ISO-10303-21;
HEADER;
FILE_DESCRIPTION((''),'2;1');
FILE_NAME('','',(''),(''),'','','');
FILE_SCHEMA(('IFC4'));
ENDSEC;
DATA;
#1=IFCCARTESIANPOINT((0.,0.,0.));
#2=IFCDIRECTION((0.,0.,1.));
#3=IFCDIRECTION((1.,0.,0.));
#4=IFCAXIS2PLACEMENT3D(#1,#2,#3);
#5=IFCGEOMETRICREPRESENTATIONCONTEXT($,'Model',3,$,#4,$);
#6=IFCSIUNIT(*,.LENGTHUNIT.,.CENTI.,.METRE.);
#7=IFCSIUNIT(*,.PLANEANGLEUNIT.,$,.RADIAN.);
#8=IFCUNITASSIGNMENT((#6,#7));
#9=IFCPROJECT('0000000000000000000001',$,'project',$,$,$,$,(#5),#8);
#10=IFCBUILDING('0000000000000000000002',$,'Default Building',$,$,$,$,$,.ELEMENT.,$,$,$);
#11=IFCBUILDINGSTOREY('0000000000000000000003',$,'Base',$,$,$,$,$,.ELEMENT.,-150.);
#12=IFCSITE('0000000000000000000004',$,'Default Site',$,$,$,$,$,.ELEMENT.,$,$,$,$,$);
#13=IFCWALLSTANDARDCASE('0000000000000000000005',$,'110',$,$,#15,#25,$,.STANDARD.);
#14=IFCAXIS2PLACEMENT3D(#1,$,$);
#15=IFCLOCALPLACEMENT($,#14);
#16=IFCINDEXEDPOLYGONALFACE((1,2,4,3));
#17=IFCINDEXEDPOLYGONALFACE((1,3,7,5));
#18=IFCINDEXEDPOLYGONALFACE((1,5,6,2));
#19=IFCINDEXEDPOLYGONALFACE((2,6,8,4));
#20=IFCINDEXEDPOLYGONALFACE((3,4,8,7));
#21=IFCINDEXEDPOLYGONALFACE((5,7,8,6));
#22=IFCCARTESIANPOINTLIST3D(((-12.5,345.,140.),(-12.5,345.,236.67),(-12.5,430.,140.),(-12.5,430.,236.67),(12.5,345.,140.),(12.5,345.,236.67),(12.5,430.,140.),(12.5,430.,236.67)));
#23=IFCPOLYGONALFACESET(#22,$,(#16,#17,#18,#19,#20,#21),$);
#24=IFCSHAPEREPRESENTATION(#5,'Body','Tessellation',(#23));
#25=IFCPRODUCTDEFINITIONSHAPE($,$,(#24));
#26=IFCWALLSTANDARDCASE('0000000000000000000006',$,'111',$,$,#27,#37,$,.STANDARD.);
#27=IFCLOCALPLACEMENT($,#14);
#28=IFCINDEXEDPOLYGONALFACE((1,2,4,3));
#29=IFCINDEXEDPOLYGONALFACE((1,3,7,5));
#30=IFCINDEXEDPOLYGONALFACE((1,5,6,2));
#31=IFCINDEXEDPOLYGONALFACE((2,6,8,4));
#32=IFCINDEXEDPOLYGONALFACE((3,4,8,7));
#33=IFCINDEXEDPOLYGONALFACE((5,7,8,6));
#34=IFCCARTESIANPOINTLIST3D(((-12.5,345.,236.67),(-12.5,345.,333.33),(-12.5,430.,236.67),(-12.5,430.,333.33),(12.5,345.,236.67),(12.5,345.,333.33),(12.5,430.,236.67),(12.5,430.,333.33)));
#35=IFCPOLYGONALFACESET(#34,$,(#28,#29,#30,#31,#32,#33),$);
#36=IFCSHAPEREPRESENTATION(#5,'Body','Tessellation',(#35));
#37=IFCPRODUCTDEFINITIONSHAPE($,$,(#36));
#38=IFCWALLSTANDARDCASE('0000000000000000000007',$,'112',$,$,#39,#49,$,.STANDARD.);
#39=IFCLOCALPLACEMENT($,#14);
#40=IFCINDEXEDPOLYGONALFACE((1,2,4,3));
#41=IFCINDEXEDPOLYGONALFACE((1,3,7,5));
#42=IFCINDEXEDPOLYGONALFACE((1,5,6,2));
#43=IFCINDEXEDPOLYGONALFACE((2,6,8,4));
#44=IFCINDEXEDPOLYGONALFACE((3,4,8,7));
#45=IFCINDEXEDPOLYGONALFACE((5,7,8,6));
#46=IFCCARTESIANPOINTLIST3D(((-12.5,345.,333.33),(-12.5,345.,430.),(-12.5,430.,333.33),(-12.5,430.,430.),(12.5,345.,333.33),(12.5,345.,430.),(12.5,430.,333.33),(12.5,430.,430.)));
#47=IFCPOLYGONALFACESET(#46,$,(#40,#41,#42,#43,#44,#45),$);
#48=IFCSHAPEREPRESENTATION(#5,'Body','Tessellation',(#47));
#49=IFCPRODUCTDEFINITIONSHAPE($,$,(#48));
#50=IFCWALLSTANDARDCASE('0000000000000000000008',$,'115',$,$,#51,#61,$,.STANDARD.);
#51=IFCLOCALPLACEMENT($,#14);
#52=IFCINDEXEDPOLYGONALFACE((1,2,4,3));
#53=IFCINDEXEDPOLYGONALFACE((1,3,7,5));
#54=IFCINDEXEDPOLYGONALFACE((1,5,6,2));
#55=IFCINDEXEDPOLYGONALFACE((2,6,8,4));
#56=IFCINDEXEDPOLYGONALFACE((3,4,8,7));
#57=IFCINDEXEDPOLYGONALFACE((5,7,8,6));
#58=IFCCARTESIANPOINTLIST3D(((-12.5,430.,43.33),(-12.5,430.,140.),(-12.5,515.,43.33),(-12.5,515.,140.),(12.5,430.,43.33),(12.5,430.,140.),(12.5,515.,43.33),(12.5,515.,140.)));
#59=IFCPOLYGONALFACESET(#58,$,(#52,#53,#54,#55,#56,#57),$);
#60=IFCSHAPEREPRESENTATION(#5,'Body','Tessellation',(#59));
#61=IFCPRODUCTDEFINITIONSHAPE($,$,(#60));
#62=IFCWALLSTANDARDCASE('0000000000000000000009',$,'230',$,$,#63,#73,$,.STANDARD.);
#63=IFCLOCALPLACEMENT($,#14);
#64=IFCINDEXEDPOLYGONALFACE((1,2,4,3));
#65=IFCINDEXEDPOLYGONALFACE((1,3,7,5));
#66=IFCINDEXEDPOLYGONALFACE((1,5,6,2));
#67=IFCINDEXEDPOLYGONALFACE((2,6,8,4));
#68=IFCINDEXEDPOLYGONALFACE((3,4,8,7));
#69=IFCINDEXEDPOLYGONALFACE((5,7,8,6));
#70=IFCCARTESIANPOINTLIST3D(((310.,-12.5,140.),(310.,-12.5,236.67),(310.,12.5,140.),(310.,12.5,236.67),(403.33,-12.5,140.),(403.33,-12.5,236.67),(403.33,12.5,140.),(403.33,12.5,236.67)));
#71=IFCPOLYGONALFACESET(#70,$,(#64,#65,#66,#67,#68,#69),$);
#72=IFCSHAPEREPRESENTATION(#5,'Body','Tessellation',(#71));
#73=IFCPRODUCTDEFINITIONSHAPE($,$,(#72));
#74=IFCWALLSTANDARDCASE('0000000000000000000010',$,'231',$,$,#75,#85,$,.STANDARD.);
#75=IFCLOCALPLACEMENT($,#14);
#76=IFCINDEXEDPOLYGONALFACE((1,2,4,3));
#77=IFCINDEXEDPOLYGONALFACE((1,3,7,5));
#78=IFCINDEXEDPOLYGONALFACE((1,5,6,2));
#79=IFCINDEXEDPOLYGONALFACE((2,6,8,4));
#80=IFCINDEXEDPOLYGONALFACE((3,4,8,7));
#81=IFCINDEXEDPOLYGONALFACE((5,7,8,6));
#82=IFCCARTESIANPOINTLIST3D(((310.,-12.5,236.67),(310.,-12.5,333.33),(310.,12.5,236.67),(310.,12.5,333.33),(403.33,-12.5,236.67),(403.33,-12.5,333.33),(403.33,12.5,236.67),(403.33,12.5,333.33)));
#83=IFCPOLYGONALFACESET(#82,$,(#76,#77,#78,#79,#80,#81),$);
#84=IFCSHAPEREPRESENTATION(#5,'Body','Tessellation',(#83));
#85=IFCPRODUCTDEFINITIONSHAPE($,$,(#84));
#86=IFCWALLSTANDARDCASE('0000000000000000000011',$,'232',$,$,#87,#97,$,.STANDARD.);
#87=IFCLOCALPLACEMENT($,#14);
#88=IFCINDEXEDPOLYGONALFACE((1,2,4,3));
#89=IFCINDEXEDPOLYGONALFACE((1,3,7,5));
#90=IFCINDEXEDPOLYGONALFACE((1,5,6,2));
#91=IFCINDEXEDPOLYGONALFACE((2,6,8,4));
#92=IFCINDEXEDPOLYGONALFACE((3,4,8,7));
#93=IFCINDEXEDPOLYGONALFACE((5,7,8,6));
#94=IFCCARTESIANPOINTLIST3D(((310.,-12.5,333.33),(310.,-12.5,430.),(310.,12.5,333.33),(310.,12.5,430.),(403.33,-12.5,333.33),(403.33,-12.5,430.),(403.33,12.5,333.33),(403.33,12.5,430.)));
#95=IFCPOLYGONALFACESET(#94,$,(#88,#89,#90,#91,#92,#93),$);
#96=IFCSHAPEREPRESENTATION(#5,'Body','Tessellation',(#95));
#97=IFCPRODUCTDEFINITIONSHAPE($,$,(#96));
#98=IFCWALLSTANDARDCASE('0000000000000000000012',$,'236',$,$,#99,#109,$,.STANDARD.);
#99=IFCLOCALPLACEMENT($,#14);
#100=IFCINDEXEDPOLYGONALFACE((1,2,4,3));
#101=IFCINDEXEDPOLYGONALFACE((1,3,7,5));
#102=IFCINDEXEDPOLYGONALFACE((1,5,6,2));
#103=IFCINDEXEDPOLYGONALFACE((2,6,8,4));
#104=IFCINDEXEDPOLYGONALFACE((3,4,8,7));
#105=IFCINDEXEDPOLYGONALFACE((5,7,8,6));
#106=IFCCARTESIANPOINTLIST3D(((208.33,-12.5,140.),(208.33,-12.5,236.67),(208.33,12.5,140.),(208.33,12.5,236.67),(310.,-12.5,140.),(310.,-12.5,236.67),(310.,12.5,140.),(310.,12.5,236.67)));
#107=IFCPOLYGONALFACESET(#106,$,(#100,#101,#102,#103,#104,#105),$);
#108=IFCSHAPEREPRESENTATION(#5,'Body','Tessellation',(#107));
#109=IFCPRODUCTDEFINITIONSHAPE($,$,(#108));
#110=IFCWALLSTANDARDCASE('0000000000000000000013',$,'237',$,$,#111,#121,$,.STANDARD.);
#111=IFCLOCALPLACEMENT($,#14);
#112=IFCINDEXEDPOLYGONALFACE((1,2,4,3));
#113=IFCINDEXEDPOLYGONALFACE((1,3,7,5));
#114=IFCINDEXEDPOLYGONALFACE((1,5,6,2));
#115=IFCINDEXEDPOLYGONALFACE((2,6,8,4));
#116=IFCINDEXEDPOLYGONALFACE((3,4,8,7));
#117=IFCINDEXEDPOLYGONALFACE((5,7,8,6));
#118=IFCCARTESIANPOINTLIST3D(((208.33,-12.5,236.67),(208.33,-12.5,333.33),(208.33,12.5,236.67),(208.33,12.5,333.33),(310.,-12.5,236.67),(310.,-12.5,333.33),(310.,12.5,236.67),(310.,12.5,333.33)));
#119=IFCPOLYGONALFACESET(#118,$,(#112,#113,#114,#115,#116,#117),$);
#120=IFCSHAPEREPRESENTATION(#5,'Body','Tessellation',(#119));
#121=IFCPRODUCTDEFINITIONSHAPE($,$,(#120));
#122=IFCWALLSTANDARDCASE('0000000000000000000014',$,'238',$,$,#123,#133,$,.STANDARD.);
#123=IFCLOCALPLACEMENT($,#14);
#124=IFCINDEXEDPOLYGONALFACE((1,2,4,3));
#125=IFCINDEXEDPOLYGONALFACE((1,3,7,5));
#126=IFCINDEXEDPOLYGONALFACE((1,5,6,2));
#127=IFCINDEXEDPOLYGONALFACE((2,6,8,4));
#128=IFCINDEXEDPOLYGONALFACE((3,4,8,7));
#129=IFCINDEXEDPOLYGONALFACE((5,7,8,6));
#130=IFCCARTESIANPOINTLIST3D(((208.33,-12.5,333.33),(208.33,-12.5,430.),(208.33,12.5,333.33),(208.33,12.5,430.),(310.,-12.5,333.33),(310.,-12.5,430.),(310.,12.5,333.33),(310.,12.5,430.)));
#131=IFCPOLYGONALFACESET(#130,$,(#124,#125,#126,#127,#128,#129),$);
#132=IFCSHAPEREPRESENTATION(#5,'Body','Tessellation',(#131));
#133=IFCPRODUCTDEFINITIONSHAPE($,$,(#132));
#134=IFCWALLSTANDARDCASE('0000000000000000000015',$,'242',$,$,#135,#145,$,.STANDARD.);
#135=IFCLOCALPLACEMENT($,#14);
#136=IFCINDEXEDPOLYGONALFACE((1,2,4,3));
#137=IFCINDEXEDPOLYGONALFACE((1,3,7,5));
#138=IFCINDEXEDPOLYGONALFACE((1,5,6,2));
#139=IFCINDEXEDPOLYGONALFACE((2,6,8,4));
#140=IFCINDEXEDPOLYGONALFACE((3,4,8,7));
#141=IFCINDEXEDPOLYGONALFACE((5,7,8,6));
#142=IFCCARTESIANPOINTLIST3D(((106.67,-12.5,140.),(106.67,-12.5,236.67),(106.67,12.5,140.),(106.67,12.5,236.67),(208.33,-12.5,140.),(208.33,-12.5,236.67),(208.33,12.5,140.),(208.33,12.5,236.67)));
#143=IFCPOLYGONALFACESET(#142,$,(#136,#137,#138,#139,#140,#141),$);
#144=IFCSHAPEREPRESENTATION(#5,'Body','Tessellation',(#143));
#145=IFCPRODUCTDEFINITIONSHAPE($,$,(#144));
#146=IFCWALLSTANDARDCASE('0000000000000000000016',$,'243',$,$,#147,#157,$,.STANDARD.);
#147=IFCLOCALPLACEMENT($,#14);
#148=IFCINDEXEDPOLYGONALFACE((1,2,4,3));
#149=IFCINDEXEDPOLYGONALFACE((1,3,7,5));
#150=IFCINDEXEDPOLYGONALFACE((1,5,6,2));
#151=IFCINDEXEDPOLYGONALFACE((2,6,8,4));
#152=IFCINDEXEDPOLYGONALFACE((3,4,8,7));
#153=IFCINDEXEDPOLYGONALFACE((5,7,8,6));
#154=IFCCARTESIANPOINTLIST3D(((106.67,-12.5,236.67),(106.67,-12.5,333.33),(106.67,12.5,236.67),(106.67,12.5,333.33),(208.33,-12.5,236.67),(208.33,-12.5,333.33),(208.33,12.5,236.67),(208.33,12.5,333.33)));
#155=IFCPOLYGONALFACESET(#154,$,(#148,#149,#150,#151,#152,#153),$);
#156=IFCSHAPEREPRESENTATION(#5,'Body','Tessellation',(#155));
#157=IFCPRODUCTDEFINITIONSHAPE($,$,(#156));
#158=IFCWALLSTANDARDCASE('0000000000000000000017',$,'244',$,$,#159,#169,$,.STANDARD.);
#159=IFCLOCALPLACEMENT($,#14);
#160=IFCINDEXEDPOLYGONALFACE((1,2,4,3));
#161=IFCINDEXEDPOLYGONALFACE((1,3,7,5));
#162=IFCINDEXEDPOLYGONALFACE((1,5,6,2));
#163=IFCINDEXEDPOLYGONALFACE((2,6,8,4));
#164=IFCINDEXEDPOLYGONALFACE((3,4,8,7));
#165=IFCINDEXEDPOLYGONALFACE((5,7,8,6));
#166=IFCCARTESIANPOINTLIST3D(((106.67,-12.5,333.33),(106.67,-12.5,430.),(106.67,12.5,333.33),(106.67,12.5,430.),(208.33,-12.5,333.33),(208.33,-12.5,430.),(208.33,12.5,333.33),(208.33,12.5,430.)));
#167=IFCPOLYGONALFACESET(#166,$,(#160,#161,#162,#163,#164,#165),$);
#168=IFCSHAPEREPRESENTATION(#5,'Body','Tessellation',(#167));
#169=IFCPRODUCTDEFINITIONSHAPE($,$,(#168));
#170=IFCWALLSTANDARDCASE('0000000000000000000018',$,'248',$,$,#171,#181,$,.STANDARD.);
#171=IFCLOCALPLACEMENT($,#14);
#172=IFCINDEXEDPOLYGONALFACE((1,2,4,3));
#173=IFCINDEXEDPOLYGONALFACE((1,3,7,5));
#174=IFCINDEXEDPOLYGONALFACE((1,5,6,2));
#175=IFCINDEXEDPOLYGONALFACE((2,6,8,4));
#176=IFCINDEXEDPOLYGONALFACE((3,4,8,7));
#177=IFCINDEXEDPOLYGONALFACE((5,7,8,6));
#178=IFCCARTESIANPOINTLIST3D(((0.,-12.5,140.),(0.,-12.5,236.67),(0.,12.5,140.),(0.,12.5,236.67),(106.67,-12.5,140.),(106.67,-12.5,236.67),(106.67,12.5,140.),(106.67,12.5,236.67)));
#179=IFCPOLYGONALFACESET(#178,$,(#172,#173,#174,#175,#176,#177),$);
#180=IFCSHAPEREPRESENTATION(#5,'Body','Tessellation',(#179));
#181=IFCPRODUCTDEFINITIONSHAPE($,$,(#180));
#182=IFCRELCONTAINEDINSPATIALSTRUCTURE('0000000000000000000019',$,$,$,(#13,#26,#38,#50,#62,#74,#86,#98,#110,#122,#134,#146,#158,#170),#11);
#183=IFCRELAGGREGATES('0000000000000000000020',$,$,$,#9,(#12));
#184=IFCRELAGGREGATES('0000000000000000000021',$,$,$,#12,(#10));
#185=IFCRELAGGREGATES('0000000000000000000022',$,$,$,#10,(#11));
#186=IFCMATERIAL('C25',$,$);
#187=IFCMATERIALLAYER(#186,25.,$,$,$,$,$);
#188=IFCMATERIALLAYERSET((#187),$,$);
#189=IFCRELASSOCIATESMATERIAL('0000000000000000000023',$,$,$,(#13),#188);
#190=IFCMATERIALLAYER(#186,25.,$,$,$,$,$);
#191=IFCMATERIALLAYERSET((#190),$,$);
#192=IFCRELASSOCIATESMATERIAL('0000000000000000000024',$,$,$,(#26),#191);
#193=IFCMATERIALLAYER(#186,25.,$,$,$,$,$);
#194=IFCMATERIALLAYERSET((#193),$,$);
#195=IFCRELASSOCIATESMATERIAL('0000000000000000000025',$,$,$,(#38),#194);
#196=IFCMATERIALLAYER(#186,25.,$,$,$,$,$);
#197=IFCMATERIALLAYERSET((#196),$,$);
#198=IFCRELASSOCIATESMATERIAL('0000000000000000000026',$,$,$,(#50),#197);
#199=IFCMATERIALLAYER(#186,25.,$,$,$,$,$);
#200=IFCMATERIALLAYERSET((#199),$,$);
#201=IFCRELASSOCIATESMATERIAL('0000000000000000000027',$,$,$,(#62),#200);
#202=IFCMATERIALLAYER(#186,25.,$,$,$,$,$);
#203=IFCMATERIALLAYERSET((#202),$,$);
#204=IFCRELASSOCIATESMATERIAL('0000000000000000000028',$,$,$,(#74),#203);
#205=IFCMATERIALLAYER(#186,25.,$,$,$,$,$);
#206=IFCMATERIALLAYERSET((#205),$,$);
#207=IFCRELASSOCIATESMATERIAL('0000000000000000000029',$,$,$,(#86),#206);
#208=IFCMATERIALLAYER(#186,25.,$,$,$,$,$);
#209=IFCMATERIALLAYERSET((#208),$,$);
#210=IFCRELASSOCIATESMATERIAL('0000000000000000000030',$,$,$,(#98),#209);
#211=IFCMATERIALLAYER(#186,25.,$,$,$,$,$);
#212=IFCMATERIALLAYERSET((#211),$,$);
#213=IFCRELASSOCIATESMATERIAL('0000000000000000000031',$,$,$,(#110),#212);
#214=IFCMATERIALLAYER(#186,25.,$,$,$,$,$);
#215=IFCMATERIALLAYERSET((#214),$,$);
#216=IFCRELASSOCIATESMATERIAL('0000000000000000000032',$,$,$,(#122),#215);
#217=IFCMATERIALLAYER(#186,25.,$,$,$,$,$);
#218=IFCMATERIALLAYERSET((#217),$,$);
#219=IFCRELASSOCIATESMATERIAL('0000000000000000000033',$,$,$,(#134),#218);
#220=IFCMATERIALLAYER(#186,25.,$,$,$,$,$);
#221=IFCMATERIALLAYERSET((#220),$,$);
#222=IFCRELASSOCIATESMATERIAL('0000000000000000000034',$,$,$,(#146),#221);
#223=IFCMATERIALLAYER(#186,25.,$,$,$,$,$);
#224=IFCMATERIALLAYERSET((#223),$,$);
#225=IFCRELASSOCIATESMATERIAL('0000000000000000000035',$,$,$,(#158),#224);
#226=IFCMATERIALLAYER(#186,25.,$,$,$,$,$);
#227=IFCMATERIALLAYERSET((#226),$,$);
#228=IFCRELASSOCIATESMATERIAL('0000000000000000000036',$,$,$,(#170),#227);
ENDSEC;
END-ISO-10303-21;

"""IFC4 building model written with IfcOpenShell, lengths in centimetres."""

from ifc_helpers import new_model, si_unit, frame, origin_with_axes, origin_2d_with_axis, place, context, project, spatial, rectangle, extrude, material, layer, layer_set, layer_usage, element, save


model = new_model("IFC4")

# Units and contexts
model_context = context("Model", 3, world=origin_with_axes())
ifc_project = project(units=[si_unit("LENGTHUNIT", "METRE", prefix="CENTI"), si_unit("PLANEANGLEUNIT", "RADIAN")], contexts=[model_context])

# Site, building, storey
site = spatial("IfcSite", under=ifc_project, Name="Default Site", CompositionType="ELEMENT")
building = spatial("IfcBuilding", under=site, Name="Default Building", CompositionType="ELEMENT")
storey = spatial("IfcBuildingStorey", under=building, Name="Base", CompositionType="ELEMENT", Elevation=-150.0)

# Walls
ifc_material = material(Name="C25")
ifc_layer_1 = layer(ifc_material, 25.0)
ifc_layer_set_1 = layer_set([ifc_layer_1])
ifc_layer_usage_1 = layer_usage(ifc_layer_set_1, "AXIS2", "POSITIVE", -25.0)
wall_1_placement = place(None, frame((0.0, 387.5, 140.0), z_axis=(0.0, 0.0, 1.0), x_axis=(0.0, 1.0, 0.0)))
element("IfcWallStandardCase", 1, at=wall_1_placement, inside=storey, material=ifc_layer_usage_1, Name="110", PredefinedType="STANDARD", context=model_context, shape_type="SweptSolid", body=[
    extrude(rectangle(XDim=85.0, YDim=25.0, at=origin_2d_with_axis()), origin_with_axes(), (0.0, 0.0, 1.0), 96.67),
])
ifc_layer_2 = layer(ifc_material, 25.0)
ifc_layer_set_2 = layer_set([ifc_layer_2])
ifc_layer_usage_2 = layer_usage(ifc_layer_set_2, "AXIS2", "POSITIVE", -25.0)
wall_2_placement = place(None, frame((0.0, 387.5, 236.67), z_axis=(0.0, 0.0, 1.0), x_axis=(0.0, 1.0, 0.0)))
element("IfcWallStandardCase", 2, at=wall_2_placement, inside=storey, material=ifc_layer_usage_2, Name="111", PredefinedType="STANDARD", context=model_context, shape_type="SweptSolid", body=[
    extrude(rectangle(XDim=85.0, YDim=25.0, at=origin_2d_with_axis()), origin_with_axes(), (0.0, 0.0, 1.0), 96.67),
])
ifc_layer_3 = layer(ifc_material, 25.0)
ifc_layer_set_3 = layer_set([ifc_layer_3])
ifc_layer_usage_3 = layer_usage(ifc_layer_set_3, "AXIS2", "POSITIVE", -25.0)
wall_3_placement = place(None, frame((0.0, 387.5, 333.33), z_axis=(0.0, 0.0, 1.0), x_axis=(0.0, 1.0, 0.0)))
element("IfcWallStandardCase", 3, at=wall_3_placement, inside=storey, material=ifc_layer_usage_3, Name="112", PredefinedType="STANDARD", context=model_context, shape_type="SweptSolid", body=[
    extrude(rectangle(XDim=85.0, YDim=25.0, at=origin_2d_with_axis()), origin_with_axes(), (0.0, 0.0, 1.0), 96.67),
])
ifc_layer_4 = layer(ifc_material, 25.0)
ifc_layer_set_4 = layer_set([ifc_layer_4])
ifc_layer_usage_4 = layer_usage(ifc_layer_set_4, "AXIS2", "POSITIVE", -25.0)
wall_4_placement = place(None, frame((0.0, 472.5, 43.33), z_axis=(0.0, 0.0, 1.0), x_axis=(0.0, 1.0, 0.0)))
element("IfcWallStandardCase", 4, at=wall_4_placement, inside=storey, material=ifc_layer_usage_4, Name="115", PredefinedType="STANDARD", context=model_context, shape_type="SweptSolid", body=[
    extrude(rectangle(XDim=85.0, YDim=25.0, at=origin_2d_with_axis()), origin_with_axes(), (0.0, 0.0, 1.0), 96.67),
])
ifc_layer_5 = layer(ifc_material, 25.0)
ifc_layer_set_5 = layer_set([ifc_layer_5])
ifc_layer_usage_5 = layer_usage(ifc_layer_set_5, "AXIS2", "POSITIVE", -25.0)
wall_5_placement = place(None, frame((356.67, 0.0, 140.0), z_axis=(0.0, 0.0, 1.0), x_axis=(-1.0, 0.0, 0.0)))
element("IfcWallStandardCase", 5, at=wall_5_placement, inside=storey, material=ifc_layer_usage_5, Name="230", PredefinedType="STANDARD", context=model_context, shape_type="SweptSolid", body=[
    extrude(rectangle(XDim=93.33, YDim=25.0, at=origin_2d_with_axis()), origin_with_axes(), (0.0, 0.0, 1.0), 96.67),
])
ifc_layer_6 = layer(ifc_material, 25.0)
ifc_layer_set_6 = layer_set([ifc_layer_6])
ifc_layer_usage_6 = layer_usage(ifc_layer_set_6, "AXIS2", "POSITIVE", -25.0)
wall_6_placement = place(None, frame((356.67, 0.0, 236.67), z_axis=(0.0, 0.0, 1.0), x_axis=(-1.0, 0.0, 0.0)))
element("IfcWallStandardCase", 6, at=wall_6_placement, inside=storey, material=ifc_layer_usage_6, Name="231", PredefinedType="STANDARD", context=model_context, shape_type="SweptSolid", body=[
    extrude(rectangle(XDim=93.33, YDim=25.0, at=origin_2d_with_axis()), origin_with_axes(), (0.0, 0.0, 1.0), 96.67),
])
ifc_layer_7 = layer(ifc_material, 25.0)
ifc_layer_set_7 = layer_set([ifc_layer_7])
ifc_layer_usage_7 = layer_usage(ifc_layer_set_7, "AXIS2", "POSITIVE", -25.0)
wall_7_placement = place(None, frame((356.67, 0.0, 333.33), z_axis=(0.0, 0.0, 1.0), x_axis=(-1.0, 0.0, 0.0)))
element("IfcWallStandardCase", 7, at=wall_7_placement, inside=storey, material=ifc_layer_usage_7, Name="232", PredefinedType="STANDARD", context=model_context, shape_type="SweptSolid", body=[
    extrude(rectangle(XDim=93.33, YDim=25.0, at=origin_2d_with_axis()), origin_with_axes(), (0.0, 0.0, 1.0), 96.67),
])
ifc_layer_8 = layer(ifc_material, 25.0)
ifc_layer_set_8 = layer_set([ifc_layer_8])
ifc_layer_usage_8 = layer_usage(ifc_layer_set_8, "AXIS2", "POSITIVE", -25.0)
wall_8_placement = place(None, frame((259.17, 0.0, 140.0), z_axis=(0.0, 0.0, 1.0), x_axis=(-1.0, 0.0, 0.0)))
element("IfcWallStandardCase", 8, at=wall_8_placement, inside=storey, material=ifc_layer_usage_8, Name="236", PredefinedType="STANDARD", context=model_context, shape_type="SweptSolid", body=[
    extrude(rectangle(XDim=101.67, YDim=25.0, at=origin_2d_with_axis()), origin_with_axes(), (0.0, 0.0, 1.0), 96.67),
])
ifc_layer_9 = layer(ifc_material, 25.0)
ifc_layer_set_9 = layer_set([ifc_layer_9])
ifc_layer_usage_9 = layer_usage(ifc_layer_set_9, "AXIS2", "POSITIVE", -25.0)
wall_9_placement = place(None, frame((259.17, 0.0, 236.67), z_axis=(0.0, 0.0, 1.0), x_axis=(-1.0, 0.0, 0.0)))
element("IfcWallStandardCase", 9, at=wall_9_placement, inside=storey, material=ifc_layer_usage_9, Name="237", PredefinedType="STANDARD", context=model_context, shape_type="SweptSolid", body=[
    extrude(rectangle(XDim=101.67, YDim=25.0, at=origin_2d_with_axis()), origin_with_axes(), (0.0, 0.0, 1.0), 96.67),
])
ifc_layer_10 = layer(ifc_material, 25.0)
ifc_layer_set_10 = layer_set([ifc_layer_10])
ifc_layer_usage_10 = layer_usage(ifc_layer_set_10, "AXIS2", "POSITIVE", -25.0)
wall_10_placement = place(None, frame((259.17, 0.0, 333.33), z_axis=(0.0, 0.0, 1.0), x_axis=(-1.0, 0.0, 0.0)))
element("IfcWallStandardCase", 10, at=wall_10_placement, inside=storey, material=ifc_layer_usage_10, Name="238", PredefinedType="STANDARD", context=model_context, shape_type="SweptSolid", body=[
    extrude(rectangle(XDim=101.67, YDim=25.0, at=origin_2d_with_axis()), origin_with_axes(), (0.0, 0.0, 1.0), 96.67),
])
ifc_layer_11 = layer(ifc_material, 25.0)
ifc_layer_set_11 = layer_set([ifc_layer_11])
ifc_layer_usage_11 = layer_usage(ifc_layer_set_11, "AXIS2", "POSITIVE", -25.0)
wall_11_placement = place(None, frame((157.5, 0.0, 140.0), z_axis=(0.0, 0.0, 1.0), x_axis=(-1.0, 0.0, 0.0)))
element("IfcWallStandardCase", 11, at=wall_11_placement, inside=storey, material=ifc_layer_usage_11, Name="242", PredefinedType="STANDARD", context=model_context, shape_type="SweptSolid", body=[
    extrude(rectangle(XDim=101.67, YDim=25.0, at=origin_2d_with_axis()), origin_with_axes(), (0.0, 0.0, 1.0), 96.67),
])
ifc_layer_12 = layer(ifc_material, 25.0)
ifc_layer_set_12 = layer_set([ifc_layer_12])
ifc_layer_usage_12 = layer_usage(ifc_layer_set_12, "AXIS2", "POSITIVE", -25.0)
wall_12_placement = place(None, frame((157.5, 0.0, 236.67), z_axis=(0.0, 0.0, 1.0), x_axis=(-1.0, 0.0, 0.0)))
element("IfcWallStandardCase", 12, at=wall_12_placement, inside=storey, material=ifc_layer_usage_12, Name="243", PredefinedType="STANDARD", context=model_context, shape_type="SweptSolid", body=[
    extrude(rectangle(XDim=101.67, YDim=25.0, at=origin_2d_with_axis()), origin_with_axes(), (0.0, 0.0, 1.0), 96.67),
])
ifc_layer_13 = layer(ifc_material, 25.0)
ifc_layer_set_13 = layer_set([ifc_layer_13])
ifc_layer_usage_13 = layer_usage(ifc_layer_set_13, "AXIS2", "POSITIVE", -25.0)
wall_13_placement = place(None, frame((157.5, 0.0, 333.33), z_axis=(0.0, 0.0, 1.0), x_axis=(-1.0, 0.0, 0.0)))
element("IfcWallStandardCase", 13, at=wall_13_placement, inside=storey, material=ifc_layer_usage_13, Name="244", PredefinedType="STANDARD", context=model_context, shape_type="SweptSolid", body=[
    extrude(rectangle(XDim=101.67, YDim=25.0, at=origin_2d_with_axis()), origin_with_axes(), (0.0, 0.0, 1.0), 96.67),
])
ifc_layer_14 = layer(ifc_material, 25.0)
ifc_layer_set_14 = layer_set([ifc_layer_14])
ifc_layer_usage_14 = layer_usage(ifc_layer_set_14, "AXIS2", "POSITIVE", -25.0)
wall_14_placement = place(None, frame((53.33, 0.0, 140.0), z_axis=(0.0, 0.0, 1.0), x_axis=(-1.0, 0.0, 0.0)))
element("IfcWallStandardCase", 14, at=wall_14_placement, inside=storey, material=ifc_layer_usage_14, Name="248", PredefinedType="STANDARD", context=model_context, shape_type="SweptSolid", body=[
    extrude(rectangle(XDim=106.67, YDim=25.0, at=origin_2d_with_axis()), origin_with_axes(), (0.0, 0.0, 1.0), 96.67),
])

save(model, "model.ifc")
